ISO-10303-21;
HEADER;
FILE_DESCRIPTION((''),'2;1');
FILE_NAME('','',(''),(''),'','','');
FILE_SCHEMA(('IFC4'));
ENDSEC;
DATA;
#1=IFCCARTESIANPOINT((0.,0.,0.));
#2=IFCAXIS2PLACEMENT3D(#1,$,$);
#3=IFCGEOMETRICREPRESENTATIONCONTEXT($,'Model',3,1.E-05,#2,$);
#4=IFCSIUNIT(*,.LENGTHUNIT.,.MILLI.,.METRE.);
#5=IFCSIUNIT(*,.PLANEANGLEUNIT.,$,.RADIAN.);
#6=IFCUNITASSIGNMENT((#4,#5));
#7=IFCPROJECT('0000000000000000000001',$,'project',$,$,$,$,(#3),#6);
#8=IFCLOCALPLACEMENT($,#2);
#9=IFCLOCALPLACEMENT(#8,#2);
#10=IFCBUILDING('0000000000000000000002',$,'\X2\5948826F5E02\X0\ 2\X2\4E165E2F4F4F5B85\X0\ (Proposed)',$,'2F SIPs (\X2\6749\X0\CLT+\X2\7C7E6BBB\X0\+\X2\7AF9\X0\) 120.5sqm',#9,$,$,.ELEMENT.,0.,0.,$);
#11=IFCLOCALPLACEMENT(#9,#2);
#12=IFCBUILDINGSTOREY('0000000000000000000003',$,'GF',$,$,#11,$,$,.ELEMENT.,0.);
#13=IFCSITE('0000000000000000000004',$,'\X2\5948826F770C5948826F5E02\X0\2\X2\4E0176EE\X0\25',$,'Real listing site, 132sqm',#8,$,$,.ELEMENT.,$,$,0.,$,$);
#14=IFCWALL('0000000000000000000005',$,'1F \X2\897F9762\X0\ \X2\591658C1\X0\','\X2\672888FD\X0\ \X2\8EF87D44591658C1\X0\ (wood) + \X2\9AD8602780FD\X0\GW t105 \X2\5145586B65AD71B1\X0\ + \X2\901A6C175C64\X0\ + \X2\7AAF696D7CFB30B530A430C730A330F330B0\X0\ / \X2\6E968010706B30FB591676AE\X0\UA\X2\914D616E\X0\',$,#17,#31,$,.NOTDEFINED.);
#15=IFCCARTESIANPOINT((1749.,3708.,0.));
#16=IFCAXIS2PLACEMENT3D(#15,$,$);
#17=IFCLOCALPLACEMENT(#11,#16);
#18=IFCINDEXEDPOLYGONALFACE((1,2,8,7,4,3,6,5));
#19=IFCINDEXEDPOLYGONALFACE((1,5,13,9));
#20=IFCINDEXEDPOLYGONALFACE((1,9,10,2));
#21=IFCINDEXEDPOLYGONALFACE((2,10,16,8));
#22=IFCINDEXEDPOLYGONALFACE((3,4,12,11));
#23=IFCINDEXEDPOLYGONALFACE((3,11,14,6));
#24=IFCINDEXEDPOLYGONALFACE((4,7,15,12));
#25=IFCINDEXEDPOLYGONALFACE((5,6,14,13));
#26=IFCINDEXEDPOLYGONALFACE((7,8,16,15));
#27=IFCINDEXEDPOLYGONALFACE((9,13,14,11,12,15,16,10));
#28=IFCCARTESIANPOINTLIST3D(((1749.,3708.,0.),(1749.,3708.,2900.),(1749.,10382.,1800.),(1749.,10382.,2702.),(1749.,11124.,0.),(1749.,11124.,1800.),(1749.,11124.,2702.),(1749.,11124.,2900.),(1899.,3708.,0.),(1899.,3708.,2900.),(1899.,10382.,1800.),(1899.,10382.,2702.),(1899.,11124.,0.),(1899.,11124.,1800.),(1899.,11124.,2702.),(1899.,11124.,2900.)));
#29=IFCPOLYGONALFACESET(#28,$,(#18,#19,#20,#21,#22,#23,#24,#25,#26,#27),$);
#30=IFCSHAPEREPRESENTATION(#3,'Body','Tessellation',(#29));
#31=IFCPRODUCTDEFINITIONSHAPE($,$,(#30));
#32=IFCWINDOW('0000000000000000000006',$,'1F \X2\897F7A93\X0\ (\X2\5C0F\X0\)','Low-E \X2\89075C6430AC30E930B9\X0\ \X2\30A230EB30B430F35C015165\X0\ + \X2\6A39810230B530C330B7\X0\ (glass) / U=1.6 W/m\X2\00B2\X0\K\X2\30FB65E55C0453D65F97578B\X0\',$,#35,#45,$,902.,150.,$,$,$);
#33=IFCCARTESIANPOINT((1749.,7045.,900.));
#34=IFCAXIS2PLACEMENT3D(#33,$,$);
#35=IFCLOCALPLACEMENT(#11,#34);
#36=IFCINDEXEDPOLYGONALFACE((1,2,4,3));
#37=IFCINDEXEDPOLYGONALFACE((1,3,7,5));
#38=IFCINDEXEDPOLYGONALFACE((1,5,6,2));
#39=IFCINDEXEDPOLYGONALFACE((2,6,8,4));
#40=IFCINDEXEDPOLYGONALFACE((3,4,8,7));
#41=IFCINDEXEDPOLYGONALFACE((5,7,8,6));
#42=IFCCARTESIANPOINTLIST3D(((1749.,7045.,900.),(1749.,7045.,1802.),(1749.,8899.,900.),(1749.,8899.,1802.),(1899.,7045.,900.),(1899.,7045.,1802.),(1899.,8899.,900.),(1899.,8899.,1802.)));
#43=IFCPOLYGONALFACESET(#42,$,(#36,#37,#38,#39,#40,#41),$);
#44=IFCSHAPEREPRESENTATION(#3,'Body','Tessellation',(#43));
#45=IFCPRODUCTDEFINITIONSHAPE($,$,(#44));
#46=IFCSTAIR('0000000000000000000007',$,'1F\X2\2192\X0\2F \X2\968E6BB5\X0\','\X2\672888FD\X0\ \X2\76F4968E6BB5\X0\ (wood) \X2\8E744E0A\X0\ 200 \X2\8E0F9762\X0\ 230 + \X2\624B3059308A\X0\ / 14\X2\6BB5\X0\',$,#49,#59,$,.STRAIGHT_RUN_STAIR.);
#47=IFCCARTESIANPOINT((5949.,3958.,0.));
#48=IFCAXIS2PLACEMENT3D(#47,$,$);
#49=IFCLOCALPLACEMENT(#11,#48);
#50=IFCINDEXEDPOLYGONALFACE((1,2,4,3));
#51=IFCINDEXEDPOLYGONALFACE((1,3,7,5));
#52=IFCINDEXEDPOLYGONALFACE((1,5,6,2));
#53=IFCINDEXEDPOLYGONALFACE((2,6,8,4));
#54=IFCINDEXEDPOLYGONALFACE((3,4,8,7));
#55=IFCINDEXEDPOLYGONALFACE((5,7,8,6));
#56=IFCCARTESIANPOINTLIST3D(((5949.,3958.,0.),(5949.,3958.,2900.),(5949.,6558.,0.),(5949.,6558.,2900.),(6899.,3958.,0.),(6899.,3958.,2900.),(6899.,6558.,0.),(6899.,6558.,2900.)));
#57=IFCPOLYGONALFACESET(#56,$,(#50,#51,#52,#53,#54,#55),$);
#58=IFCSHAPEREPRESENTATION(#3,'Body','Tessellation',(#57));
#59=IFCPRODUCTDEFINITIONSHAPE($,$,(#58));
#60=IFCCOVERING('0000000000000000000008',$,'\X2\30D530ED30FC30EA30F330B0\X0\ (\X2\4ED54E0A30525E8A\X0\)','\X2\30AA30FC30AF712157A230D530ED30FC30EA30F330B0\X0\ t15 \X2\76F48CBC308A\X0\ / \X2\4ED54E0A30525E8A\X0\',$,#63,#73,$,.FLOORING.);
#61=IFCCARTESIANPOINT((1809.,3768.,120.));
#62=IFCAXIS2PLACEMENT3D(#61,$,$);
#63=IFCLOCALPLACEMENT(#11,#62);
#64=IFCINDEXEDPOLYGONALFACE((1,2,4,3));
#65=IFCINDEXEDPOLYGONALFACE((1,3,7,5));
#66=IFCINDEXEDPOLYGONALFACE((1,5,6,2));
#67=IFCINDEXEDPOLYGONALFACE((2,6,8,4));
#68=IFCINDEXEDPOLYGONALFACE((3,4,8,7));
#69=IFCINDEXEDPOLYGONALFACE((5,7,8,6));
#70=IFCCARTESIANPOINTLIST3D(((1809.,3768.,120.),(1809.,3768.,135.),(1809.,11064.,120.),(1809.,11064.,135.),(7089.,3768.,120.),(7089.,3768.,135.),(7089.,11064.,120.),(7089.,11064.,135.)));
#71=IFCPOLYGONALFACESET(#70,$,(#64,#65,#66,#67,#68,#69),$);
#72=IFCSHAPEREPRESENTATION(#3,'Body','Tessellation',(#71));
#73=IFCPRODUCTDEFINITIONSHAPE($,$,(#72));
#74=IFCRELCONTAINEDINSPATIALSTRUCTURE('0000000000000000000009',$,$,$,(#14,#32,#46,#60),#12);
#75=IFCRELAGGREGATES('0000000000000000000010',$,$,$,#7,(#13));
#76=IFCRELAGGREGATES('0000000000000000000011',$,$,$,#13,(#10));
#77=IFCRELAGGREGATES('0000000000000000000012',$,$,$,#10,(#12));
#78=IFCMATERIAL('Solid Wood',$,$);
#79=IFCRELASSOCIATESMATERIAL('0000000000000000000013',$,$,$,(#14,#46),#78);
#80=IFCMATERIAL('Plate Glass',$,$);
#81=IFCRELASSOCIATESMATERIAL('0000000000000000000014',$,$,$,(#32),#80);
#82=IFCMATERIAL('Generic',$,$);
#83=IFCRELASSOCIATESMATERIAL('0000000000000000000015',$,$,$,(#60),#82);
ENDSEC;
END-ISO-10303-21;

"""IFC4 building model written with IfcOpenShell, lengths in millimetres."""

from ifc_helpers import new_model, si_unit, frame, frame_2d, origin, place, context, project, spatial, rectangle, extrude, material, element, fill, save


model = new_model("IFC4")

# Units and contexts
model_context = context("Model", 3, precision=1e-05, world=origin())
ifc_project = project(units=[si_unit("LENGTHUNIT", "METRE", prefix="MILLI"), si_unit("PLANEANGLEUNIT", "RADIAN")], contexts=[model_context])

# Site, building, storey
site_placement = place(None, origin())
site = spatial("IfcSite", under=ifc_project, at=site_placement, Name="奈良県奈良市2丁目25", ObjectType="Real listing site, 132sqm", CompositionType="ELEMENT", RefElevation=0.0)
building_placement = place(site_placement, origin())
building = spatial("IfcBuilding", under=site, at=building_placement, Name="奈良市 2世帯住宅 (Proposed)", ObjectType="2F SIPs (杉CLT+籾殻+竹) 120.5sqm", CompositionType="ELEMENT", ElevationOfRefHeight=0.0, ElevationOfTerrain=0.0)
storey_placement = place(building_placement, origin())
storey = spatial("IfcBuildingStorey", under=building, at=storey_placement, Name="GF", CompositionType="ELEMENT", Elevation=0.0)

# Shared definitions
ifc_material_1 = material(Name="Solid Wood")
ifc_material_2 = material(Name="Generic")

# Shared definitions
ifc_material_3 = material(Name="Plate Glass")

# Wall, opening, window
wall_1_placement = place(storey_placement, frame((1749.0, 3708.0, 0.0)))
wall_1 = element("IfcWall", 1, at=wall_1_placement, inside=storey, material=ifc_material_1, Name="1F 西面 外壁", Description="木製 軸組外壁 (wood) + 高性能GW t105 充填断熱 + 通気層 + 窯業系サイディング / 準耐火・外皮UA配慮", PredefinedType="NOTDEFINED", context=model_context, shape_type="SweptSolid", body=[
    extrude(rectangle(XDim=150.0, YDim=7416.0, at=frame_2d((75.0, 3708.0))), frame((1749.0, 3708.0, 0.0)), (0.0, 0.0, 1.0), 2900.0),
])
opening_1_placement = place(storey_placement, frame((1749.0, 7045.0, 900.0)))
opening_1 = element("IfcOpeningElement", 2, at=opening_1_placement, cuts=wall_1, PredefinedType="NOTDEFINED", context=model_context, shape_type="SweptSolid", body=[
    extrude(rectangle(XDim=150.0, YDim=1854.0, at=frame_2d((75.0, 927.0))), frame((1749.0, 7045.0, 900.0)), (0.0, 0.0, 1.0), 902.0),
])
window_1_placement = place(storey_placement, frame((1749.0, 7045.0, 900.0)))
window_1 = element("IfcWindow", 3, at=window_1_placement, inside=storey, material=ifc_material_3, Name="1F 西窓 (小)", Description="Low-E 複層ガラス アルゴン封入 + 樹脂サッシ (glass) / U=1.6 W/m²K・日射取得型", OverallHeight=902.0, OverallWidth=150.0, context=model_context, shape_type="SweptSolid", body=[
    extrude(rectangle(XDim=150.0, YDim=1854.0, at=frame_2d((75.0, 927.0))), frame((1749.0, 7045.0, 900.0)), (0.0, 0.0, 1.0), 902.0),
])
fill(opening_1, window_1)

# Stair
stair_placement = place(storey_placement, frame((5949.0, 3958.0, 0.0)))
element("IfcStair", 4, at=stair_placement, inside=storey, material=ifc_material_1, Name="1F→2F 階段", Description="木製 直階段 (wood) 蹴上 200 踏面 230 + 手すり / 14段", PredefinedType="STRAIGHT_RUN_STAIR", context=model_context, shape_type="SweptSolid", body=[
    extrude(rectangle(XDim=950.0, YDim=2600.0, at=frame_2d((475.0, 1300.0))), frame((5949.0, 3958.0, 0.0)), (0.0, 0.0, 1.0), 2900.0),
])

# Covering
covering_placement = place(storey_placement, frame((1809.0, 3768.0, 120.0)))
element("IfcCovering", 5, at=covering_placement, inside=storey, material=ifc_material_2, Name="フローリング (仕上げ床)", Description="オーク無垢フローリング t15 直貼り / 仕上げ床", PredefinedType="FLOORING", context=model_context, shape_type="SweptSolid", body=[
    extrude(rectangle(XDim=5280.0, YDim=7296.0, at=frame_2d((2640.0, 3648.0))), frame((1809.0, 3768.0, 120.0)), (0.0, 0.0, 1.0), 15.0),
])

save(model, "model.ifc")
